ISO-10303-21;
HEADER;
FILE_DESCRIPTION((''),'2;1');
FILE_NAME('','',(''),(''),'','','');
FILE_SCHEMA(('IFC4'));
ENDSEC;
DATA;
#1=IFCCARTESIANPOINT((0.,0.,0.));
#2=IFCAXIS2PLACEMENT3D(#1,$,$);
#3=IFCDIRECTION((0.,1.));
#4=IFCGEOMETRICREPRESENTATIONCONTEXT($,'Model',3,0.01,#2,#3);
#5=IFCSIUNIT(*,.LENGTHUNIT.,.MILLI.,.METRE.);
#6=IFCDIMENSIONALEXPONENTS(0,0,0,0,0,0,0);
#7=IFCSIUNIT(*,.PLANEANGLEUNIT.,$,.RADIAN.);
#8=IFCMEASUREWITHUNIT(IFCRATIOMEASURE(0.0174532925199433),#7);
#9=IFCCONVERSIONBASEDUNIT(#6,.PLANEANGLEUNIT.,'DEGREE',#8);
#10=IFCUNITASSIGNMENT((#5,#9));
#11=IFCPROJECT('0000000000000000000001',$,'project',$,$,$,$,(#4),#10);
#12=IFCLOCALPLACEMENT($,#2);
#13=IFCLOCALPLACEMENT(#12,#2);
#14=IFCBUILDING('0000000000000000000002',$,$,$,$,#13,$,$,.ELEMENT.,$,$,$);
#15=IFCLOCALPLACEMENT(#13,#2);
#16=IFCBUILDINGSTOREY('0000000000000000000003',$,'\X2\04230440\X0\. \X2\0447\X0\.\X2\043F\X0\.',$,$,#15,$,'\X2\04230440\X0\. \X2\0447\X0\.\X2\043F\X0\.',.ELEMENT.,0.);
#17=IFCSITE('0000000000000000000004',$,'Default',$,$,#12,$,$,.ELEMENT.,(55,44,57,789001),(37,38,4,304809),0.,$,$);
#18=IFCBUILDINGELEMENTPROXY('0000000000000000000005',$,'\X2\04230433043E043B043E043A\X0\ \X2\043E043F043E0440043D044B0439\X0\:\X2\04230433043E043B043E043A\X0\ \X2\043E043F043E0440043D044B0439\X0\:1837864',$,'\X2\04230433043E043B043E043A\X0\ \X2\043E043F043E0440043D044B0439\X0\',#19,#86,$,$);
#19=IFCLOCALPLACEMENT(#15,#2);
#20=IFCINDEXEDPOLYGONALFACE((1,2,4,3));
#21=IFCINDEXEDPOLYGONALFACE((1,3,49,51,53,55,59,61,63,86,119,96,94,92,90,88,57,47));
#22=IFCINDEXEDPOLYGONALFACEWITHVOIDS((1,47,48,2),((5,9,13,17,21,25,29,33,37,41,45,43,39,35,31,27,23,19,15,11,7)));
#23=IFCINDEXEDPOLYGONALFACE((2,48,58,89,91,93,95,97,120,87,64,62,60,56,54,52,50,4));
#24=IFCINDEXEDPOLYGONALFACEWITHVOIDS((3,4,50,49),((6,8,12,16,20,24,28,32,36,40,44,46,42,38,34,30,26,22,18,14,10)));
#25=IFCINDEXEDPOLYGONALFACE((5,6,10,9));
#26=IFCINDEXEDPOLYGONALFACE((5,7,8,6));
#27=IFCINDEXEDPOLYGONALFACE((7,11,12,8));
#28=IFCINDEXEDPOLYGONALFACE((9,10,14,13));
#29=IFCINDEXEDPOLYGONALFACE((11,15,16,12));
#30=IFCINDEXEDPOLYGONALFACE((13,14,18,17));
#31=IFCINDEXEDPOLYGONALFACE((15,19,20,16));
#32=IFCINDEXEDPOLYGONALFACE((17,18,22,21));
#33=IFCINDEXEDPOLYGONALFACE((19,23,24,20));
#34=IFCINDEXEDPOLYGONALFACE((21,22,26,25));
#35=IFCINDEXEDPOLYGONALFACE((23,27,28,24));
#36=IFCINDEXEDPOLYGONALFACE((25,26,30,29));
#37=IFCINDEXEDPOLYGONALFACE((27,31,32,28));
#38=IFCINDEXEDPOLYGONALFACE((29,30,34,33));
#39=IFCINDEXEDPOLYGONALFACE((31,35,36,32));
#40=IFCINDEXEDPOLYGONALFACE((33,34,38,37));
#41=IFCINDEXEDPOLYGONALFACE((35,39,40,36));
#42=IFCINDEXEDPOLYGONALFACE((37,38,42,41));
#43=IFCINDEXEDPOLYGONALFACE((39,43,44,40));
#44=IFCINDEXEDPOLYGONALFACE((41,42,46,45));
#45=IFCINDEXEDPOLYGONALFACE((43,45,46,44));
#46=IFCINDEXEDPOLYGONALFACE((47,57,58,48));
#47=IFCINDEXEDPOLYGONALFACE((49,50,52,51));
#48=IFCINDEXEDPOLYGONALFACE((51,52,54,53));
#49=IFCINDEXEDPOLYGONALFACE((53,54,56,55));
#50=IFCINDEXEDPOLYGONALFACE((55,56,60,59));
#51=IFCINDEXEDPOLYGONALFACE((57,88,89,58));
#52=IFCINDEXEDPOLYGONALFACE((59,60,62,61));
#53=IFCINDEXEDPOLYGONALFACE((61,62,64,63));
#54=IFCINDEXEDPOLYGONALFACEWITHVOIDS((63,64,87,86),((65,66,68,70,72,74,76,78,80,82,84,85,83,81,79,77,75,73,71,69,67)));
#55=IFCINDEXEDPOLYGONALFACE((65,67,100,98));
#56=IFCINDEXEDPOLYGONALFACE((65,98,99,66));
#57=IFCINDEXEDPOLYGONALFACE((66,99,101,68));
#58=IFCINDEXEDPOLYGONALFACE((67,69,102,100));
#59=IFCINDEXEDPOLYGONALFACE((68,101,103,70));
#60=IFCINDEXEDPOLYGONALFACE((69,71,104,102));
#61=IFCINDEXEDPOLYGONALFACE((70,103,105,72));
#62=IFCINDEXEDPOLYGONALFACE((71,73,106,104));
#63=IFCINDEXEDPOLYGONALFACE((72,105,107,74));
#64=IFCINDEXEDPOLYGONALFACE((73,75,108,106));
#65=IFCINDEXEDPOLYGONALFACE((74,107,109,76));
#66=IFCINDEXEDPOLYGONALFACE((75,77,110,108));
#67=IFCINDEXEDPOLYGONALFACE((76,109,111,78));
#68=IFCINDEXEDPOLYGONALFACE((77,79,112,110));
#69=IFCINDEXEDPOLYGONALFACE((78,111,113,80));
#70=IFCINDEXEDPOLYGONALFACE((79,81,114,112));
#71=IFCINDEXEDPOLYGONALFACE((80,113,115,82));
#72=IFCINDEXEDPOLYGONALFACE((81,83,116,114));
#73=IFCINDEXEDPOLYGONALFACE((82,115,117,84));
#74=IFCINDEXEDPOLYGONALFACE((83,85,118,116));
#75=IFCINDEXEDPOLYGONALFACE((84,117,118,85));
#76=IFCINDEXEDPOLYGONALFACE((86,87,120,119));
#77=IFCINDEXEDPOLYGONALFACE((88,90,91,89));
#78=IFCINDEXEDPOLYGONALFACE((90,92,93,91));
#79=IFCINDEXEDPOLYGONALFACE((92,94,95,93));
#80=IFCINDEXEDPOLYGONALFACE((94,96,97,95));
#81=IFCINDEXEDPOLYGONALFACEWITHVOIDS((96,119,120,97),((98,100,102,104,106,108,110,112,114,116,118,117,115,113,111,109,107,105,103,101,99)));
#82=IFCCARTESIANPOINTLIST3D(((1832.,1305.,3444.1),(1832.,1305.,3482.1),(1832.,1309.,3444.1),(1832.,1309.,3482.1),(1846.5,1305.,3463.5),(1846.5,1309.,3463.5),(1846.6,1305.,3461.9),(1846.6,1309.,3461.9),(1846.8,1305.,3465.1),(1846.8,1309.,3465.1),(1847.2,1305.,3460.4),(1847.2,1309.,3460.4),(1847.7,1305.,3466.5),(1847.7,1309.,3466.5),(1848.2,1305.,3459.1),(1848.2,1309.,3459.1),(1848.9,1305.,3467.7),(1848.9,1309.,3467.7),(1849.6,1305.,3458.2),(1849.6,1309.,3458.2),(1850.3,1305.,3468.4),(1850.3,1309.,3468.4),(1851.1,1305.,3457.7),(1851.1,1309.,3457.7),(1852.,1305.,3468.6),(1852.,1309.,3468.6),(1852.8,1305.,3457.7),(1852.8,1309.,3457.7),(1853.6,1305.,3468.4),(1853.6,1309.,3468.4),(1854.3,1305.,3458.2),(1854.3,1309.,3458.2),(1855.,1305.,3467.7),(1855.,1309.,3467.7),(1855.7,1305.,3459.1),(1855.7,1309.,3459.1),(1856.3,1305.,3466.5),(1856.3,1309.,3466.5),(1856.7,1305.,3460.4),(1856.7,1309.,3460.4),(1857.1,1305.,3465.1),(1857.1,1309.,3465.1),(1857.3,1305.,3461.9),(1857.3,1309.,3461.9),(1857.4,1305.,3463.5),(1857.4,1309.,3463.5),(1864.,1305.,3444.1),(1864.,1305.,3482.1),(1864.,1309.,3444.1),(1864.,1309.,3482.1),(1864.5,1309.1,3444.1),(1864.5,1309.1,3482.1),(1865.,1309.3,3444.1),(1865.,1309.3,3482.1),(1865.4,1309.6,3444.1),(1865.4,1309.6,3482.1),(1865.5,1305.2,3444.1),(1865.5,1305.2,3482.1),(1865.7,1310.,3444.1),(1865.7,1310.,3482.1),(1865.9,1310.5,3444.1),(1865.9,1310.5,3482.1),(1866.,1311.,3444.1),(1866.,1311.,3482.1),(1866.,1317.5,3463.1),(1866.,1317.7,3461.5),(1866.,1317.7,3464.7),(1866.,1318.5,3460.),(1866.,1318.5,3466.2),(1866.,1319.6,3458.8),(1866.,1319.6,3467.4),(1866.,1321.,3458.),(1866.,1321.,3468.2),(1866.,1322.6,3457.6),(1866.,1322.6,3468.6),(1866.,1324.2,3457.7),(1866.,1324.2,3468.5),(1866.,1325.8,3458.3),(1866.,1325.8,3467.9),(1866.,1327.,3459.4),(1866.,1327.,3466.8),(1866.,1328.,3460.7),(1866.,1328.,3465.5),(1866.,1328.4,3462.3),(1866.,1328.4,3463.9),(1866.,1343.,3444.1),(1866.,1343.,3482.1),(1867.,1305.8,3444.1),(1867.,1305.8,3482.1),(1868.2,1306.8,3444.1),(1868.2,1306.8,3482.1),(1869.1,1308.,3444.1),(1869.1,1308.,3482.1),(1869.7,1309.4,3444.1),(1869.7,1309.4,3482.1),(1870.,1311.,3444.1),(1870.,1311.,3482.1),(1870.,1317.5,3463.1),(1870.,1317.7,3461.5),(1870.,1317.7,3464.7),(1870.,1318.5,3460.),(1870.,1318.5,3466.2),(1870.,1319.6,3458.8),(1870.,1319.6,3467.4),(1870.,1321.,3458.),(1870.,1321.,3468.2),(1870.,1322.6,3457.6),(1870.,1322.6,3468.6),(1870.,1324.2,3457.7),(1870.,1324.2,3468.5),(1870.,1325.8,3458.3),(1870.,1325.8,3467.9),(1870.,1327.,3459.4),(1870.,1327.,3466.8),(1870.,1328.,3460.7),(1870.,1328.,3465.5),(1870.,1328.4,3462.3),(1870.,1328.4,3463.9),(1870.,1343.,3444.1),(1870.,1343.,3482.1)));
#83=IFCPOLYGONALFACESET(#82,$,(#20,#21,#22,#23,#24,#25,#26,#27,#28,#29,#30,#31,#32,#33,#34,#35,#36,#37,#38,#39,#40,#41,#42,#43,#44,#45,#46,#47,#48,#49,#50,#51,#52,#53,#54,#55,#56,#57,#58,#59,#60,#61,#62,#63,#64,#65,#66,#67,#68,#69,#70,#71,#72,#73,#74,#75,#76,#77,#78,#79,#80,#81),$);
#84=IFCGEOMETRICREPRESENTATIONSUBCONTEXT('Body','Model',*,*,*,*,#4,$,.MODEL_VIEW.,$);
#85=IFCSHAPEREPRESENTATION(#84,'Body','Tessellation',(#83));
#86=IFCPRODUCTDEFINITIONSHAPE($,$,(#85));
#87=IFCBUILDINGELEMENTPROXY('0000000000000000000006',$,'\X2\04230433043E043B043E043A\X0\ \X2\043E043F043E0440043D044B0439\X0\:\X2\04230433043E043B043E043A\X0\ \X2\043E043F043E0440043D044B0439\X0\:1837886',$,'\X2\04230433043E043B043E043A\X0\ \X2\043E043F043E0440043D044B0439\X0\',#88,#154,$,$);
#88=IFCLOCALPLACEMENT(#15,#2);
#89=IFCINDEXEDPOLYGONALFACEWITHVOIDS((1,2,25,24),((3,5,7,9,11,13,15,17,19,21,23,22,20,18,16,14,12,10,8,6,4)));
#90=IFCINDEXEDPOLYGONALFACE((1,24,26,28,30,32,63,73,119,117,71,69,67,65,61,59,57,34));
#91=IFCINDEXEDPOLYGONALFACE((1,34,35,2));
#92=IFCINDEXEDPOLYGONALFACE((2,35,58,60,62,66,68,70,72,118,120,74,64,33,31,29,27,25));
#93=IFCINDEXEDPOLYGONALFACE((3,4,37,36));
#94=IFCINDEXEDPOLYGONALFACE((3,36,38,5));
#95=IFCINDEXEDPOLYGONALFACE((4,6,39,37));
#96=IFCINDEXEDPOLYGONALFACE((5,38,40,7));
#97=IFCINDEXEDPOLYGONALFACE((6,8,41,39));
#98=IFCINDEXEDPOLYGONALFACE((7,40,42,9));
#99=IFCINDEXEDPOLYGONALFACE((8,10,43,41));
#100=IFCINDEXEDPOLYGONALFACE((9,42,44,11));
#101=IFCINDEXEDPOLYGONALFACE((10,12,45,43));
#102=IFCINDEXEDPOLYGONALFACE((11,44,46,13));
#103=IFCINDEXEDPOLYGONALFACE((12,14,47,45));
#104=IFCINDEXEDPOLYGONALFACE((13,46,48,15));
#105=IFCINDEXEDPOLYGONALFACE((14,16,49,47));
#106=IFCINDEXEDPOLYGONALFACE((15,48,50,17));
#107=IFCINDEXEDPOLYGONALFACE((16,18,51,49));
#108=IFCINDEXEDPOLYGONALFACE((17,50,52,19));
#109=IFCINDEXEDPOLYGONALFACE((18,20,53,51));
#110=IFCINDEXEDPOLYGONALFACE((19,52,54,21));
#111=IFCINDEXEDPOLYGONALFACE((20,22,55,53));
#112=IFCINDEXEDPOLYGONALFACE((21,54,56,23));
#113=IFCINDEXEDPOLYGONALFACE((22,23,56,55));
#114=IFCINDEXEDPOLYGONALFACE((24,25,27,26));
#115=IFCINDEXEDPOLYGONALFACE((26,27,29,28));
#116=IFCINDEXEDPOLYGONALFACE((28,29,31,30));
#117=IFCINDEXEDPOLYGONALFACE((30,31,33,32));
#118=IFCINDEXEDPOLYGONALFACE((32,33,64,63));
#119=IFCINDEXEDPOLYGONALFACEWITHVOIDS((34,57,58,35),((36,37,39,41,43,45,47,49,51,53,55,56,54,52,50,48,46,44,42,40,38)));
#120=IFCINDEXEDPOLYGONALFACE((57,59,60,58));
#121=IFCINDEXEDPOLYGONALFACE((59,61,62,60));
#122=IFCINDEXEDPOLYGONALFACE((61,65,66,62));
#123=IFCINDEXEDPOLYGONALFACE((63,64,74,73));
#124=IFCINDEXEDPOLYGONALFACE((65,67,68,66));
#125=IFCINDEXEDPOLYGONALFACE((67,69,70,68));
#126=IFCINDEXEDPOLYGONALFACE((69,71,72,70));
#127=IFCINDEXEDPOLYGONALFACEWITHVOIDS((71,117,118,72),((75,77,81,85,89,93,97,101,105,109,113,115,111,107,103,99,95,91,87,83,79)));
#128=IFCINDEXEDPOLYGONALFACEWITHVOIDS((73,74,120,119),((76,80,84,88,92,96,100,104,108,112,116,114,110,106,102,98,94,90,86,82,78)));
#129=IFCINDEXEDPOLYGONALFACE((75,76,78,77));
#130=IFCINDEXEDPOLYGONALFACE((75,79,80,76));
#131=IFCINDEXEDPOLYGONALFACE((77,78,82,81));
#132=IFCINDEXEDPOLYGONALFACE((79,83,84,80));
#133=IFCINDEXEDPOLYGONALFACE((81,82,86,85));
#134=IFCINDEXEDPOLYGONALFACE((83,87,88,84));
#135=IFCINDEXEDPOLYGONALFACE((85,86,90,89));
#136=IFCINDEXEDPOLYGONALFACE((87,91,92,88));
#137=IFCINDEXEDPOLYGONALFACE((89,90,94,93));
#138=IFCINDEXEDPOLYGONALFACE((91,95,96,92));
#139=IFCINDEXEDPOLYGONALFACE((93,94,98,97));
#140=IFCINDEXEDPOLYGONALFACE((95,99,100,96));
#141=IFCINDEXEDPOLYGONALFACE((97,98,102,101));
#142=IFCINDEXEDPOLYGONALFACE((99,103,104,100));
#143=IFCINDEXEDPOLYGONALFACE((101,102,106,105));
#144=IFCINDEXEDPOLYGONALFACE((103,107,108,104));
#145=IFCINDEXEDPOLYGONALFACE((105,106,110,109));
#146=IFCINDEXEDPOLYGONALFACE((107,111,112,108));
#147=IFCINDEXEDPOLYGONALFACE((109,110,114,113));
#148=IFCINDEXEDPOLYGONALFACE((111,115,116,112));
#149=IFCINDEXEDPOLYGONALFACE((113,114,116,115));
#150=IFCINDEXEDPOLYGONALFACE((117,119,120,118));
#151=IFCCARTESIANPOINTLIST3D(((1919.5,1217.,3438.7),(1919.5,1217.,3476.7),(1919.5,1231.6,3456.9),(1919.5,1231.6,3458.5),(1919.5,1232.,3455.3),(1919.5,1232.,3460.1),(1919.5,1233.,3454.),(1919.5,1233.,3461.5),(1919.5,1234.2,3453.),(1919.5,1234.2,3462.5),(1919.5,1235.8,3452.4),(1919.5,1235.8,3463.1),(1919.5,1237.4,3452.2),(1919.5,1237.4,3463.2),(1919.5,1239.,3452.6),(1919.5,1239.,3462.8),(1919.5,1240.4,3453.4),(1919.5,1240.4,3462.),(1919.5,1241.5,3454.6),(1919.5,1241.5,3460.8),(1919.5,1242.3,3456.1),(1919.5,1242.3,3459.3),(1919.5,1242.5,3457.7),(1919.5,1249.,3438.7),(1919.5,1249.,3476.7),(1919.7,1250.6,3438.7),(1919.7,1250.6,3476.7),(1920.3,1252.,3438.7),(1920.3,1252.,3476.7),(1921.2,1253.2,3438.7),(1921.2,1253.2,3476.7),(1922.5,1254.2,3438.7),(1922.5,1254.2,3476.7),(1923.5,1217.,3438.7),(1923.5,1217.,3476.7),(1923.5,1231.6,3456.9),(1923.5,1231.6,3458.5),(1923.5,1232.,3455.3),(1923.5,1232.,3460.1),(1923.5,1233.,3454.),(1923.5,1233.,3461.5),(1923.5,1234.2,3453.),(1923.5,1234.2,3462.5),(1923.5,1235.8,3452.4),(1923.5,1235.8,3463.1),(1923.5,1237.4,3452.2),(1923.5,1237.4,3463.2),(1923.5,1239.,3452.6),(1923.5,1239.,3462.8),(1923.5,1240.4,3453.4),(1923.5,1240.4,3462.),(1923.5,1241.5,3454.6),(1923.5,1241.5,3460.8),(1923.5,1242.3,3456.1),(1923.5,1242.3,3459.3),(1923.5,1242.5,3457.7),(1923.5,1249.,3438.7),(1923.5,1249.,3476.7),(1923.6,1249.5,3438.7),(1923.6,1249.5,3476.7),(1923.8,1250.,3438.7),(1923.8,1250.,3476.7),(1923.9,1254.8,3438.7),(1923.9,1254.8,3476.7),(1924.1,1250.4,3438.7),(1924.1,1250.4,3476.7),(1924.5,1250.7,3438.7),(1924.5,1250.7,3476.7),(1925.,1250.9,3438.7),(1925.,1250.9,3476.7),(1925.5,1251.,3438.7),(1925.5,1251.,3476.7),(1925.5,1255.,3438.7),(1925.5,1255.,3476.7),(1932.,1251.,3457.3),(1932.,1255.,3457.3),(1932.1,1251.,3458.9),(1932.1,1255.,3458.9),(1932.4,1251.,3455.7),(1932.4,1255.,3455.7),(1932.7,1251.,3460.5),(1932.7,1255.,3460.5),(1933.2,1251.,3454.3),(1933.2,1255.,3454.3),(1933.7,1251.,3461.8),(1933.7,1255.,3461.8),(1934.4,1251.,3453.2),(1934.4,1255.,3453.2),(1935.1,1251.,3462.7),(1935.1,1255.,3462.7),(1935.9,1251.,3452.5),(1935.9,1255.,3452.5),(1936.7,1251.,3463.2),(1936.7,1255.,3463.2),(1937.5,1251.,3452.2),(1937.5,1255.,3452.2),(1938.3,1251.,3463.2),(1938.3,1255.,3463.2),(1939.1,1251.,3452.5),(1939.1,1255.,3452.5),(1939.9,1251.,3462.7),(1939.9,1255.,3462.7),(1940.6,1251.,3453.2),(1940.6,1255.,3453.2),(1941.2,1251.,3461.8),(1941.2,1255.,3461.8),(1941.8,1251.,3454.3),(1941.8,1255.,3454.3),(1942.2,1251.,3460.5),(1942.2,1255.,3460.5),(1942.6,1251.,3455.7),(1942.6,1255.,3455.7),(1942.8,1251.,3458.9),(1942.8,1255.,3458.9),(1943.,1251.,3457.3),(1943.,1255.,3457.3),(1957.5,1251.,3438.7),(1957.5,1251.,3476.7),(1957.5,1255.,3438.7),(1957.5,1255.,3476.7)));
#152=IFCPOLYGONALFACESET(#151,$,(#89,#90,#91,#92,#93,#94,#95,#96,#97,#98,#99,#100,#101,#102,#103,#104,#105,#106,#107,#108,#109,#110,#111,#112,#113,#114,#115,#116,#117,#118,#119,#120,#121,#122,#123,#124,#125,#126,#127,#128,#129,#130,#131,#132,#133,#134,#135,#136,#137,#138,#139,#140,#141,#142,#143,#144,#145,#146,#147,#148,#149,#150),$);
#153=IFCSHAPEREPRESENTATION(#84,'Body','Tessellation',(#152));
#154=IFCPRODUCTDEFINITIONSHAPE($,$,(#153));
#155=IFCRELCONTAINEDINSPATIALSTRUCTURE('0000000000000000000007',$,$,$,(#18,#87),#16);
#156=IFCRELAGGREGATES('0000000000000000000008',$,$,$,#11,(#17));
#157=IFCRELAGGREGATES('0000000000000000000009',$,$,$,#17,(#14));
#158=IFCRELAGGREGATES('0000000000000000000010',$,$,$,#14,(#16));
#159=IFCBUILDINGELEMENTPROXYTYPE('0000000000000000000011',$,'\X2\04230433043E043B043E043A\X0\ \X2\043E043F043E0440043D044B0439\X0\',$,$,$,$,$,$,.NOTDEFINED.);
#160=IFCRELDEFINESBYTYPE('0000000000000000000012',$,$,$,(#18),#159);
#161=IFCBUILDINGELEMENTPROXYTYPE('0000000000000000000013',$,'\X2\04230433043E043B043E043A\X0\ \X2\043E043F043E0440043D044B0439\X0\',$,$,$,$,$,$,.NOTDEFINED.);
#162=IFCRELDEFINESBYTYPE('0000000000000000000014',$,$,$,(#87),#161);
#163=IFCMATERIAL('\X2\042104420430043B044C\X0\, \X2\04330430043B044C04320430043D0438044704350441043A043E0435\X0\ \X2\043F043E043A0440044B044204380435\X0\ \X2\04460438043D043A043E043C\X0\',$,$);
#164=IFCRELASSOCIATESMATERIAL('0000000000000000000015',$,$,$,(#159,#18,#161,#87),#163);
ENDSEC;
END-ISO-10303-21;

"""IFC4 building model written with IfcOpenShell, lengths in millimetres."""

from ifc_helpers import new_model, entity, si_unit, converted_unit, direction, frame, frame_2d, origin, place, context, subcontext, project, spatial, polyline, circle_curve, parameter, trimmed, segment, composite_curve, circle, outline, extrude, source, transform, mapped, material, type_object, type_shapes, element, save


model = new_model("IFC4")

# Units and contexts
model_context = context("Model", 3, precision=0.01, world=origin(), true_north=direction((0.0, 1.0)))
body_context = subcontext(model_context, "Body", "Model", "MODEL_VIEW")
ifc_project = project(units=[si_unit("LENGTHUNIT", "METRE", prefix="MILLI"), converted_unit("PLANEANGLEUNIT", "DEGREE", entity("IfcRatioMeasure", 0.0174532925199433), si_unit("PLANEANGLEUNIT", "RADIAN"), dimensions=[0, 0, 0, 0, 0, 0, 0])], contexts=[model_context])

# Site, building, storey
site_placement = place(None, origin())
site = spatial("IfcSite", under=ifc_project, at=site_placement, Name="Default", CompositionType="ELEMENT", RefLatitude=(55, 44, 57, 789001), RefLongitude=(37, 38, 4, 304809), RefElevation=0.0)
building_placement = place(site_placement, origin())
building = spatial("IfcBuilding", under=site, at=building_placement, CompositionType="ELEMENT")
storey_placement = place(building_placement, origin())
storey = spatial("IfcBuildingStorey", under=building, at=storey_placement, Name="Ур. ч.п.", LongName="Ур. ч.п.", CompositionType="ELEMENT", Elevation=0.0)

# Building element proxies, openings
ifc_material_1 = material(Name="Сталь, гальваническое покрытие цинком")
building_element_proxy_type_1 = type_object("IfcBuildingElementProxyType", Name="Уголок опорный", material=ifc_material_1)
shared_shape_1 = source(origin(), body_context, "Body", "SweptSolid", [
    extrude(outline(composite_curve([segment(polyline([(-6.0, -12.0), (26.0, -12.0)]), True, "CONTINUOUS"), segment(polyline([(26.0, -12.0), (26.0, -8.0)]), True, "CONTINUOUS"), segment(polyline([(26.0, -8.0), (-6.0, -8.0)]), True, "CONTINUOUS"), segment(trimmed(circle_curve(frame_2d((-6.0, -6.0), x_axis=(0.0, -1.0)), 2.0), [parameter(270.0)], [parameter(0.0)], True, "PARAMETER"), False, "CONTINUOUS"), segment(polyline([(-8.0, -6.0), (-8.0, 26.0)]), True, "CONTINUOUS"), segment(polyline([(-8.0, 26.0), (-12.0, 26.0)]), True, "CONTINUOUS"), segment(polyline([(-12.0, 26.0), (-12.0, -6.0)]), True, "CONTINUOUS"), segment(trimmed(circle_curve(frame_2d((-6.0, -6.0), x_axis=(0.0, -1.0)), 6.0), [parameter(270.0)], [parameter(360.0)], True, "PARAMETER"), True, "CONTINUOUS")], self_intersect=False)), frame((12.0, -19.0, 12.0), z_axis=(0.0, 1.0, 0.0), x_axis=(0.0, 0.0, 1.0)), (0.0, 0.0, 1.0), 38.0),
])
type_shapes(building_element_proxy_type_1, [shared_shape_1])
proxy_1_placement = place(storey_placement, frame((1870.0, 1305.0, 3463.1), z_axis=(0.0, 1.0, 0.0), x_axis=(-1.0, 0.0, 0.0)))
proxy_1 = element("IfcBuildingElementProxy", 1, at=proxy_1_placement, inside=storey, type_object=building_element_proxy_type_1, material=ifc_material_1, Name="Уголок опорный:Уголок опорный:1837864", ObjectType="Уголок опорный", context=body_context, shape_type="MappedRepresentation", body=[
    mapped(shared_shape_1, transform((0.0, 0.0, 0.0), scale=1.0)),
])
opening_1_placement = place(storey_placement, frame((1870.0, 1305.0, 3463.1)))
element("IfcOpeningElement", 2, at=opening_1_placement, cuts=proxy_1, ObjectType="Opening", PredefinedType="OPENING", context=body_context, shape_type="SweptSolid", body=[
    extrude(circle(Radius=5.5, at=frame_2d((0.0, 0.0), x_axis=(1.0, 0.0))), frame((-4.0, 18.0, 0.0), z_axis=(1.0, 0.0, 0.0), x_axis=(0.0, -1.0, 0.0)), (0.0, 0.0, 1.0), 4.0),
])
opening_2_placement = place(storey_placement, frame((1870.0, 1305.0, 3463.1)))
element("IfcOpeningElement", 3, at=opening_2_placement, cuts=proxy_1, ObjectType="Opening", PredefinedType="OPENING", context=body_context, shape_type="SweptSolid", body=[
    extrude(circle(Radius=5.5, at=frame_2d((0.0, 0.0), x_axis=(1.0, 0.0))), frame((-18.0, 0.0, 0.0), z_axis=(0.0, 1.0, 0.0), x_axis=(0.0, 0.0, 1.0)), (0.0, 0.0, 1.0), 4.0),
])
building_element_proxy_type_2 = type_object("IfcBuildingElementProxyType", Name="Уголок опорный", material=ifc_material_1)
shared_shape_2 = source(origin(), body_context, "Body", "SweptSolid", [
    extrude(outline(composite_curve([segment(polyline([(-6.0, -12.0), (26.0, -12.0)]), True, "CONTINUOUS"), segment(polyline([(26.0, -12.0), (26.0, -8.0)]), True, "CONTINUOUS"), segment(polyline([(26.0, -8.0), (-6.0, -8.0)]), True, "CONTINUOUS"), segment(trimmed(circle_curve(frame_2d((-6.0, -6.0), x_axis=(0.0, -1.0)), 2.0), [parameter(270.0)], [parameter(0.0)], True, "PARAMETER"), False, "CONTINUOUS"), segment(polyline([(-8.0, -6.0), (-8.0, 26.0)]), True, "CONTINUOUS"), segment(polyline([(-8.0, 26.0), (-12.0, 26.0)]), True, "CONTINUOUS"), segment(polyline([(-12.0, 26.0), (-12.0, -6.0)]), True, "CONTINUOUS"), segment(trimmed(circle_curve(frame_2d((-6.0, -6.0), x_axis=(0.0, -1.0)), 6.0), [parameter(270.0)], [parameter(360.0)], True, "PARAMETER"), True, "CONTINUOUS")], self_intersect=False)), frame((12.0, -19.0, 12.0), z_axis=(0.0, 1.0, 0.0), x_axis=(0.0, 0.0, 1.0)), (0.0, 0.0, 1.0), 38.0),
])
type_shapes(building_element_proxy_type_2, [shared_shape_2])
proxy_2_placement = place(storey_placement, frame((1919.5, 1255.0, 3457.7), z_axis=(0.0, -1.0, 0.0), x_axis=(1.0, 0.0, 0.0)))
proxy_2 = element("IfcBuildingElementProxy", 4, at=proxy_2_placement, inside=storey, type_object=building_element_proxy_type_2, material=ifc_material_1, Name="Уголок опорный:Уголок опорный:1837886", ObjectType="Уголок опорный", context=body_context, shape_type="MappedRepresentation", body=[
    mapped(shared_shape_2, transform((0.0, 0.0, 0.0), scale=1.0)),
])
opening_3_placement = place(storey_placement, frame((1919.5, 1255.0, 3457.7), z_axis=(0.0, 0.0, -1.0), x_axis=(1.0, 0.0, 0.0)))
element("IfcOpeningElement", 5, at=opening_3_placement, cuts=proxy_2, ObjectType="Opening", PredefinedType="OPENING", context=body_context, shape_type="SweptSolid", body=[
    extrude(circle(Radius=5.5, at=frame_2d((0.0, 0.0), x_axis=(1.0, 0.0))), frame((4.0, 18.0, 0.0), z_axis=(-1.0, 0.0, 0.0), x_axis=(0.0, -1.0, 0.0)), (0.0, 0.0, 1.0), 4.0),
])
opening_4_placement = place(storey_placement, frame((1919.5, 1255.0, 3457.7), z_axis=(0.0, 0.0, -1.0), x_axis=(1.0, 0.0, 0.0)))
element("IfcOpeningElement", 6, at=opening_4_placement, cuts=proxy_2, ObjectType="Opening", PredefinedType="OPENING", context=body_context, shape_type="SweptSolid", body=[
    extrude(circle(Radius=5.5, at=frame_2d((0.0, 0.0), x_axis=(1.0, 0.0))), frame((18.0, 0.0, 0.0), z_axis=(0.0, 1.0, 0.0), x_axis=(0.0, 0.0, 1.0)), (0.0, 0.0, 1.0), 4.0),
])

save(model, "model.ifc")
